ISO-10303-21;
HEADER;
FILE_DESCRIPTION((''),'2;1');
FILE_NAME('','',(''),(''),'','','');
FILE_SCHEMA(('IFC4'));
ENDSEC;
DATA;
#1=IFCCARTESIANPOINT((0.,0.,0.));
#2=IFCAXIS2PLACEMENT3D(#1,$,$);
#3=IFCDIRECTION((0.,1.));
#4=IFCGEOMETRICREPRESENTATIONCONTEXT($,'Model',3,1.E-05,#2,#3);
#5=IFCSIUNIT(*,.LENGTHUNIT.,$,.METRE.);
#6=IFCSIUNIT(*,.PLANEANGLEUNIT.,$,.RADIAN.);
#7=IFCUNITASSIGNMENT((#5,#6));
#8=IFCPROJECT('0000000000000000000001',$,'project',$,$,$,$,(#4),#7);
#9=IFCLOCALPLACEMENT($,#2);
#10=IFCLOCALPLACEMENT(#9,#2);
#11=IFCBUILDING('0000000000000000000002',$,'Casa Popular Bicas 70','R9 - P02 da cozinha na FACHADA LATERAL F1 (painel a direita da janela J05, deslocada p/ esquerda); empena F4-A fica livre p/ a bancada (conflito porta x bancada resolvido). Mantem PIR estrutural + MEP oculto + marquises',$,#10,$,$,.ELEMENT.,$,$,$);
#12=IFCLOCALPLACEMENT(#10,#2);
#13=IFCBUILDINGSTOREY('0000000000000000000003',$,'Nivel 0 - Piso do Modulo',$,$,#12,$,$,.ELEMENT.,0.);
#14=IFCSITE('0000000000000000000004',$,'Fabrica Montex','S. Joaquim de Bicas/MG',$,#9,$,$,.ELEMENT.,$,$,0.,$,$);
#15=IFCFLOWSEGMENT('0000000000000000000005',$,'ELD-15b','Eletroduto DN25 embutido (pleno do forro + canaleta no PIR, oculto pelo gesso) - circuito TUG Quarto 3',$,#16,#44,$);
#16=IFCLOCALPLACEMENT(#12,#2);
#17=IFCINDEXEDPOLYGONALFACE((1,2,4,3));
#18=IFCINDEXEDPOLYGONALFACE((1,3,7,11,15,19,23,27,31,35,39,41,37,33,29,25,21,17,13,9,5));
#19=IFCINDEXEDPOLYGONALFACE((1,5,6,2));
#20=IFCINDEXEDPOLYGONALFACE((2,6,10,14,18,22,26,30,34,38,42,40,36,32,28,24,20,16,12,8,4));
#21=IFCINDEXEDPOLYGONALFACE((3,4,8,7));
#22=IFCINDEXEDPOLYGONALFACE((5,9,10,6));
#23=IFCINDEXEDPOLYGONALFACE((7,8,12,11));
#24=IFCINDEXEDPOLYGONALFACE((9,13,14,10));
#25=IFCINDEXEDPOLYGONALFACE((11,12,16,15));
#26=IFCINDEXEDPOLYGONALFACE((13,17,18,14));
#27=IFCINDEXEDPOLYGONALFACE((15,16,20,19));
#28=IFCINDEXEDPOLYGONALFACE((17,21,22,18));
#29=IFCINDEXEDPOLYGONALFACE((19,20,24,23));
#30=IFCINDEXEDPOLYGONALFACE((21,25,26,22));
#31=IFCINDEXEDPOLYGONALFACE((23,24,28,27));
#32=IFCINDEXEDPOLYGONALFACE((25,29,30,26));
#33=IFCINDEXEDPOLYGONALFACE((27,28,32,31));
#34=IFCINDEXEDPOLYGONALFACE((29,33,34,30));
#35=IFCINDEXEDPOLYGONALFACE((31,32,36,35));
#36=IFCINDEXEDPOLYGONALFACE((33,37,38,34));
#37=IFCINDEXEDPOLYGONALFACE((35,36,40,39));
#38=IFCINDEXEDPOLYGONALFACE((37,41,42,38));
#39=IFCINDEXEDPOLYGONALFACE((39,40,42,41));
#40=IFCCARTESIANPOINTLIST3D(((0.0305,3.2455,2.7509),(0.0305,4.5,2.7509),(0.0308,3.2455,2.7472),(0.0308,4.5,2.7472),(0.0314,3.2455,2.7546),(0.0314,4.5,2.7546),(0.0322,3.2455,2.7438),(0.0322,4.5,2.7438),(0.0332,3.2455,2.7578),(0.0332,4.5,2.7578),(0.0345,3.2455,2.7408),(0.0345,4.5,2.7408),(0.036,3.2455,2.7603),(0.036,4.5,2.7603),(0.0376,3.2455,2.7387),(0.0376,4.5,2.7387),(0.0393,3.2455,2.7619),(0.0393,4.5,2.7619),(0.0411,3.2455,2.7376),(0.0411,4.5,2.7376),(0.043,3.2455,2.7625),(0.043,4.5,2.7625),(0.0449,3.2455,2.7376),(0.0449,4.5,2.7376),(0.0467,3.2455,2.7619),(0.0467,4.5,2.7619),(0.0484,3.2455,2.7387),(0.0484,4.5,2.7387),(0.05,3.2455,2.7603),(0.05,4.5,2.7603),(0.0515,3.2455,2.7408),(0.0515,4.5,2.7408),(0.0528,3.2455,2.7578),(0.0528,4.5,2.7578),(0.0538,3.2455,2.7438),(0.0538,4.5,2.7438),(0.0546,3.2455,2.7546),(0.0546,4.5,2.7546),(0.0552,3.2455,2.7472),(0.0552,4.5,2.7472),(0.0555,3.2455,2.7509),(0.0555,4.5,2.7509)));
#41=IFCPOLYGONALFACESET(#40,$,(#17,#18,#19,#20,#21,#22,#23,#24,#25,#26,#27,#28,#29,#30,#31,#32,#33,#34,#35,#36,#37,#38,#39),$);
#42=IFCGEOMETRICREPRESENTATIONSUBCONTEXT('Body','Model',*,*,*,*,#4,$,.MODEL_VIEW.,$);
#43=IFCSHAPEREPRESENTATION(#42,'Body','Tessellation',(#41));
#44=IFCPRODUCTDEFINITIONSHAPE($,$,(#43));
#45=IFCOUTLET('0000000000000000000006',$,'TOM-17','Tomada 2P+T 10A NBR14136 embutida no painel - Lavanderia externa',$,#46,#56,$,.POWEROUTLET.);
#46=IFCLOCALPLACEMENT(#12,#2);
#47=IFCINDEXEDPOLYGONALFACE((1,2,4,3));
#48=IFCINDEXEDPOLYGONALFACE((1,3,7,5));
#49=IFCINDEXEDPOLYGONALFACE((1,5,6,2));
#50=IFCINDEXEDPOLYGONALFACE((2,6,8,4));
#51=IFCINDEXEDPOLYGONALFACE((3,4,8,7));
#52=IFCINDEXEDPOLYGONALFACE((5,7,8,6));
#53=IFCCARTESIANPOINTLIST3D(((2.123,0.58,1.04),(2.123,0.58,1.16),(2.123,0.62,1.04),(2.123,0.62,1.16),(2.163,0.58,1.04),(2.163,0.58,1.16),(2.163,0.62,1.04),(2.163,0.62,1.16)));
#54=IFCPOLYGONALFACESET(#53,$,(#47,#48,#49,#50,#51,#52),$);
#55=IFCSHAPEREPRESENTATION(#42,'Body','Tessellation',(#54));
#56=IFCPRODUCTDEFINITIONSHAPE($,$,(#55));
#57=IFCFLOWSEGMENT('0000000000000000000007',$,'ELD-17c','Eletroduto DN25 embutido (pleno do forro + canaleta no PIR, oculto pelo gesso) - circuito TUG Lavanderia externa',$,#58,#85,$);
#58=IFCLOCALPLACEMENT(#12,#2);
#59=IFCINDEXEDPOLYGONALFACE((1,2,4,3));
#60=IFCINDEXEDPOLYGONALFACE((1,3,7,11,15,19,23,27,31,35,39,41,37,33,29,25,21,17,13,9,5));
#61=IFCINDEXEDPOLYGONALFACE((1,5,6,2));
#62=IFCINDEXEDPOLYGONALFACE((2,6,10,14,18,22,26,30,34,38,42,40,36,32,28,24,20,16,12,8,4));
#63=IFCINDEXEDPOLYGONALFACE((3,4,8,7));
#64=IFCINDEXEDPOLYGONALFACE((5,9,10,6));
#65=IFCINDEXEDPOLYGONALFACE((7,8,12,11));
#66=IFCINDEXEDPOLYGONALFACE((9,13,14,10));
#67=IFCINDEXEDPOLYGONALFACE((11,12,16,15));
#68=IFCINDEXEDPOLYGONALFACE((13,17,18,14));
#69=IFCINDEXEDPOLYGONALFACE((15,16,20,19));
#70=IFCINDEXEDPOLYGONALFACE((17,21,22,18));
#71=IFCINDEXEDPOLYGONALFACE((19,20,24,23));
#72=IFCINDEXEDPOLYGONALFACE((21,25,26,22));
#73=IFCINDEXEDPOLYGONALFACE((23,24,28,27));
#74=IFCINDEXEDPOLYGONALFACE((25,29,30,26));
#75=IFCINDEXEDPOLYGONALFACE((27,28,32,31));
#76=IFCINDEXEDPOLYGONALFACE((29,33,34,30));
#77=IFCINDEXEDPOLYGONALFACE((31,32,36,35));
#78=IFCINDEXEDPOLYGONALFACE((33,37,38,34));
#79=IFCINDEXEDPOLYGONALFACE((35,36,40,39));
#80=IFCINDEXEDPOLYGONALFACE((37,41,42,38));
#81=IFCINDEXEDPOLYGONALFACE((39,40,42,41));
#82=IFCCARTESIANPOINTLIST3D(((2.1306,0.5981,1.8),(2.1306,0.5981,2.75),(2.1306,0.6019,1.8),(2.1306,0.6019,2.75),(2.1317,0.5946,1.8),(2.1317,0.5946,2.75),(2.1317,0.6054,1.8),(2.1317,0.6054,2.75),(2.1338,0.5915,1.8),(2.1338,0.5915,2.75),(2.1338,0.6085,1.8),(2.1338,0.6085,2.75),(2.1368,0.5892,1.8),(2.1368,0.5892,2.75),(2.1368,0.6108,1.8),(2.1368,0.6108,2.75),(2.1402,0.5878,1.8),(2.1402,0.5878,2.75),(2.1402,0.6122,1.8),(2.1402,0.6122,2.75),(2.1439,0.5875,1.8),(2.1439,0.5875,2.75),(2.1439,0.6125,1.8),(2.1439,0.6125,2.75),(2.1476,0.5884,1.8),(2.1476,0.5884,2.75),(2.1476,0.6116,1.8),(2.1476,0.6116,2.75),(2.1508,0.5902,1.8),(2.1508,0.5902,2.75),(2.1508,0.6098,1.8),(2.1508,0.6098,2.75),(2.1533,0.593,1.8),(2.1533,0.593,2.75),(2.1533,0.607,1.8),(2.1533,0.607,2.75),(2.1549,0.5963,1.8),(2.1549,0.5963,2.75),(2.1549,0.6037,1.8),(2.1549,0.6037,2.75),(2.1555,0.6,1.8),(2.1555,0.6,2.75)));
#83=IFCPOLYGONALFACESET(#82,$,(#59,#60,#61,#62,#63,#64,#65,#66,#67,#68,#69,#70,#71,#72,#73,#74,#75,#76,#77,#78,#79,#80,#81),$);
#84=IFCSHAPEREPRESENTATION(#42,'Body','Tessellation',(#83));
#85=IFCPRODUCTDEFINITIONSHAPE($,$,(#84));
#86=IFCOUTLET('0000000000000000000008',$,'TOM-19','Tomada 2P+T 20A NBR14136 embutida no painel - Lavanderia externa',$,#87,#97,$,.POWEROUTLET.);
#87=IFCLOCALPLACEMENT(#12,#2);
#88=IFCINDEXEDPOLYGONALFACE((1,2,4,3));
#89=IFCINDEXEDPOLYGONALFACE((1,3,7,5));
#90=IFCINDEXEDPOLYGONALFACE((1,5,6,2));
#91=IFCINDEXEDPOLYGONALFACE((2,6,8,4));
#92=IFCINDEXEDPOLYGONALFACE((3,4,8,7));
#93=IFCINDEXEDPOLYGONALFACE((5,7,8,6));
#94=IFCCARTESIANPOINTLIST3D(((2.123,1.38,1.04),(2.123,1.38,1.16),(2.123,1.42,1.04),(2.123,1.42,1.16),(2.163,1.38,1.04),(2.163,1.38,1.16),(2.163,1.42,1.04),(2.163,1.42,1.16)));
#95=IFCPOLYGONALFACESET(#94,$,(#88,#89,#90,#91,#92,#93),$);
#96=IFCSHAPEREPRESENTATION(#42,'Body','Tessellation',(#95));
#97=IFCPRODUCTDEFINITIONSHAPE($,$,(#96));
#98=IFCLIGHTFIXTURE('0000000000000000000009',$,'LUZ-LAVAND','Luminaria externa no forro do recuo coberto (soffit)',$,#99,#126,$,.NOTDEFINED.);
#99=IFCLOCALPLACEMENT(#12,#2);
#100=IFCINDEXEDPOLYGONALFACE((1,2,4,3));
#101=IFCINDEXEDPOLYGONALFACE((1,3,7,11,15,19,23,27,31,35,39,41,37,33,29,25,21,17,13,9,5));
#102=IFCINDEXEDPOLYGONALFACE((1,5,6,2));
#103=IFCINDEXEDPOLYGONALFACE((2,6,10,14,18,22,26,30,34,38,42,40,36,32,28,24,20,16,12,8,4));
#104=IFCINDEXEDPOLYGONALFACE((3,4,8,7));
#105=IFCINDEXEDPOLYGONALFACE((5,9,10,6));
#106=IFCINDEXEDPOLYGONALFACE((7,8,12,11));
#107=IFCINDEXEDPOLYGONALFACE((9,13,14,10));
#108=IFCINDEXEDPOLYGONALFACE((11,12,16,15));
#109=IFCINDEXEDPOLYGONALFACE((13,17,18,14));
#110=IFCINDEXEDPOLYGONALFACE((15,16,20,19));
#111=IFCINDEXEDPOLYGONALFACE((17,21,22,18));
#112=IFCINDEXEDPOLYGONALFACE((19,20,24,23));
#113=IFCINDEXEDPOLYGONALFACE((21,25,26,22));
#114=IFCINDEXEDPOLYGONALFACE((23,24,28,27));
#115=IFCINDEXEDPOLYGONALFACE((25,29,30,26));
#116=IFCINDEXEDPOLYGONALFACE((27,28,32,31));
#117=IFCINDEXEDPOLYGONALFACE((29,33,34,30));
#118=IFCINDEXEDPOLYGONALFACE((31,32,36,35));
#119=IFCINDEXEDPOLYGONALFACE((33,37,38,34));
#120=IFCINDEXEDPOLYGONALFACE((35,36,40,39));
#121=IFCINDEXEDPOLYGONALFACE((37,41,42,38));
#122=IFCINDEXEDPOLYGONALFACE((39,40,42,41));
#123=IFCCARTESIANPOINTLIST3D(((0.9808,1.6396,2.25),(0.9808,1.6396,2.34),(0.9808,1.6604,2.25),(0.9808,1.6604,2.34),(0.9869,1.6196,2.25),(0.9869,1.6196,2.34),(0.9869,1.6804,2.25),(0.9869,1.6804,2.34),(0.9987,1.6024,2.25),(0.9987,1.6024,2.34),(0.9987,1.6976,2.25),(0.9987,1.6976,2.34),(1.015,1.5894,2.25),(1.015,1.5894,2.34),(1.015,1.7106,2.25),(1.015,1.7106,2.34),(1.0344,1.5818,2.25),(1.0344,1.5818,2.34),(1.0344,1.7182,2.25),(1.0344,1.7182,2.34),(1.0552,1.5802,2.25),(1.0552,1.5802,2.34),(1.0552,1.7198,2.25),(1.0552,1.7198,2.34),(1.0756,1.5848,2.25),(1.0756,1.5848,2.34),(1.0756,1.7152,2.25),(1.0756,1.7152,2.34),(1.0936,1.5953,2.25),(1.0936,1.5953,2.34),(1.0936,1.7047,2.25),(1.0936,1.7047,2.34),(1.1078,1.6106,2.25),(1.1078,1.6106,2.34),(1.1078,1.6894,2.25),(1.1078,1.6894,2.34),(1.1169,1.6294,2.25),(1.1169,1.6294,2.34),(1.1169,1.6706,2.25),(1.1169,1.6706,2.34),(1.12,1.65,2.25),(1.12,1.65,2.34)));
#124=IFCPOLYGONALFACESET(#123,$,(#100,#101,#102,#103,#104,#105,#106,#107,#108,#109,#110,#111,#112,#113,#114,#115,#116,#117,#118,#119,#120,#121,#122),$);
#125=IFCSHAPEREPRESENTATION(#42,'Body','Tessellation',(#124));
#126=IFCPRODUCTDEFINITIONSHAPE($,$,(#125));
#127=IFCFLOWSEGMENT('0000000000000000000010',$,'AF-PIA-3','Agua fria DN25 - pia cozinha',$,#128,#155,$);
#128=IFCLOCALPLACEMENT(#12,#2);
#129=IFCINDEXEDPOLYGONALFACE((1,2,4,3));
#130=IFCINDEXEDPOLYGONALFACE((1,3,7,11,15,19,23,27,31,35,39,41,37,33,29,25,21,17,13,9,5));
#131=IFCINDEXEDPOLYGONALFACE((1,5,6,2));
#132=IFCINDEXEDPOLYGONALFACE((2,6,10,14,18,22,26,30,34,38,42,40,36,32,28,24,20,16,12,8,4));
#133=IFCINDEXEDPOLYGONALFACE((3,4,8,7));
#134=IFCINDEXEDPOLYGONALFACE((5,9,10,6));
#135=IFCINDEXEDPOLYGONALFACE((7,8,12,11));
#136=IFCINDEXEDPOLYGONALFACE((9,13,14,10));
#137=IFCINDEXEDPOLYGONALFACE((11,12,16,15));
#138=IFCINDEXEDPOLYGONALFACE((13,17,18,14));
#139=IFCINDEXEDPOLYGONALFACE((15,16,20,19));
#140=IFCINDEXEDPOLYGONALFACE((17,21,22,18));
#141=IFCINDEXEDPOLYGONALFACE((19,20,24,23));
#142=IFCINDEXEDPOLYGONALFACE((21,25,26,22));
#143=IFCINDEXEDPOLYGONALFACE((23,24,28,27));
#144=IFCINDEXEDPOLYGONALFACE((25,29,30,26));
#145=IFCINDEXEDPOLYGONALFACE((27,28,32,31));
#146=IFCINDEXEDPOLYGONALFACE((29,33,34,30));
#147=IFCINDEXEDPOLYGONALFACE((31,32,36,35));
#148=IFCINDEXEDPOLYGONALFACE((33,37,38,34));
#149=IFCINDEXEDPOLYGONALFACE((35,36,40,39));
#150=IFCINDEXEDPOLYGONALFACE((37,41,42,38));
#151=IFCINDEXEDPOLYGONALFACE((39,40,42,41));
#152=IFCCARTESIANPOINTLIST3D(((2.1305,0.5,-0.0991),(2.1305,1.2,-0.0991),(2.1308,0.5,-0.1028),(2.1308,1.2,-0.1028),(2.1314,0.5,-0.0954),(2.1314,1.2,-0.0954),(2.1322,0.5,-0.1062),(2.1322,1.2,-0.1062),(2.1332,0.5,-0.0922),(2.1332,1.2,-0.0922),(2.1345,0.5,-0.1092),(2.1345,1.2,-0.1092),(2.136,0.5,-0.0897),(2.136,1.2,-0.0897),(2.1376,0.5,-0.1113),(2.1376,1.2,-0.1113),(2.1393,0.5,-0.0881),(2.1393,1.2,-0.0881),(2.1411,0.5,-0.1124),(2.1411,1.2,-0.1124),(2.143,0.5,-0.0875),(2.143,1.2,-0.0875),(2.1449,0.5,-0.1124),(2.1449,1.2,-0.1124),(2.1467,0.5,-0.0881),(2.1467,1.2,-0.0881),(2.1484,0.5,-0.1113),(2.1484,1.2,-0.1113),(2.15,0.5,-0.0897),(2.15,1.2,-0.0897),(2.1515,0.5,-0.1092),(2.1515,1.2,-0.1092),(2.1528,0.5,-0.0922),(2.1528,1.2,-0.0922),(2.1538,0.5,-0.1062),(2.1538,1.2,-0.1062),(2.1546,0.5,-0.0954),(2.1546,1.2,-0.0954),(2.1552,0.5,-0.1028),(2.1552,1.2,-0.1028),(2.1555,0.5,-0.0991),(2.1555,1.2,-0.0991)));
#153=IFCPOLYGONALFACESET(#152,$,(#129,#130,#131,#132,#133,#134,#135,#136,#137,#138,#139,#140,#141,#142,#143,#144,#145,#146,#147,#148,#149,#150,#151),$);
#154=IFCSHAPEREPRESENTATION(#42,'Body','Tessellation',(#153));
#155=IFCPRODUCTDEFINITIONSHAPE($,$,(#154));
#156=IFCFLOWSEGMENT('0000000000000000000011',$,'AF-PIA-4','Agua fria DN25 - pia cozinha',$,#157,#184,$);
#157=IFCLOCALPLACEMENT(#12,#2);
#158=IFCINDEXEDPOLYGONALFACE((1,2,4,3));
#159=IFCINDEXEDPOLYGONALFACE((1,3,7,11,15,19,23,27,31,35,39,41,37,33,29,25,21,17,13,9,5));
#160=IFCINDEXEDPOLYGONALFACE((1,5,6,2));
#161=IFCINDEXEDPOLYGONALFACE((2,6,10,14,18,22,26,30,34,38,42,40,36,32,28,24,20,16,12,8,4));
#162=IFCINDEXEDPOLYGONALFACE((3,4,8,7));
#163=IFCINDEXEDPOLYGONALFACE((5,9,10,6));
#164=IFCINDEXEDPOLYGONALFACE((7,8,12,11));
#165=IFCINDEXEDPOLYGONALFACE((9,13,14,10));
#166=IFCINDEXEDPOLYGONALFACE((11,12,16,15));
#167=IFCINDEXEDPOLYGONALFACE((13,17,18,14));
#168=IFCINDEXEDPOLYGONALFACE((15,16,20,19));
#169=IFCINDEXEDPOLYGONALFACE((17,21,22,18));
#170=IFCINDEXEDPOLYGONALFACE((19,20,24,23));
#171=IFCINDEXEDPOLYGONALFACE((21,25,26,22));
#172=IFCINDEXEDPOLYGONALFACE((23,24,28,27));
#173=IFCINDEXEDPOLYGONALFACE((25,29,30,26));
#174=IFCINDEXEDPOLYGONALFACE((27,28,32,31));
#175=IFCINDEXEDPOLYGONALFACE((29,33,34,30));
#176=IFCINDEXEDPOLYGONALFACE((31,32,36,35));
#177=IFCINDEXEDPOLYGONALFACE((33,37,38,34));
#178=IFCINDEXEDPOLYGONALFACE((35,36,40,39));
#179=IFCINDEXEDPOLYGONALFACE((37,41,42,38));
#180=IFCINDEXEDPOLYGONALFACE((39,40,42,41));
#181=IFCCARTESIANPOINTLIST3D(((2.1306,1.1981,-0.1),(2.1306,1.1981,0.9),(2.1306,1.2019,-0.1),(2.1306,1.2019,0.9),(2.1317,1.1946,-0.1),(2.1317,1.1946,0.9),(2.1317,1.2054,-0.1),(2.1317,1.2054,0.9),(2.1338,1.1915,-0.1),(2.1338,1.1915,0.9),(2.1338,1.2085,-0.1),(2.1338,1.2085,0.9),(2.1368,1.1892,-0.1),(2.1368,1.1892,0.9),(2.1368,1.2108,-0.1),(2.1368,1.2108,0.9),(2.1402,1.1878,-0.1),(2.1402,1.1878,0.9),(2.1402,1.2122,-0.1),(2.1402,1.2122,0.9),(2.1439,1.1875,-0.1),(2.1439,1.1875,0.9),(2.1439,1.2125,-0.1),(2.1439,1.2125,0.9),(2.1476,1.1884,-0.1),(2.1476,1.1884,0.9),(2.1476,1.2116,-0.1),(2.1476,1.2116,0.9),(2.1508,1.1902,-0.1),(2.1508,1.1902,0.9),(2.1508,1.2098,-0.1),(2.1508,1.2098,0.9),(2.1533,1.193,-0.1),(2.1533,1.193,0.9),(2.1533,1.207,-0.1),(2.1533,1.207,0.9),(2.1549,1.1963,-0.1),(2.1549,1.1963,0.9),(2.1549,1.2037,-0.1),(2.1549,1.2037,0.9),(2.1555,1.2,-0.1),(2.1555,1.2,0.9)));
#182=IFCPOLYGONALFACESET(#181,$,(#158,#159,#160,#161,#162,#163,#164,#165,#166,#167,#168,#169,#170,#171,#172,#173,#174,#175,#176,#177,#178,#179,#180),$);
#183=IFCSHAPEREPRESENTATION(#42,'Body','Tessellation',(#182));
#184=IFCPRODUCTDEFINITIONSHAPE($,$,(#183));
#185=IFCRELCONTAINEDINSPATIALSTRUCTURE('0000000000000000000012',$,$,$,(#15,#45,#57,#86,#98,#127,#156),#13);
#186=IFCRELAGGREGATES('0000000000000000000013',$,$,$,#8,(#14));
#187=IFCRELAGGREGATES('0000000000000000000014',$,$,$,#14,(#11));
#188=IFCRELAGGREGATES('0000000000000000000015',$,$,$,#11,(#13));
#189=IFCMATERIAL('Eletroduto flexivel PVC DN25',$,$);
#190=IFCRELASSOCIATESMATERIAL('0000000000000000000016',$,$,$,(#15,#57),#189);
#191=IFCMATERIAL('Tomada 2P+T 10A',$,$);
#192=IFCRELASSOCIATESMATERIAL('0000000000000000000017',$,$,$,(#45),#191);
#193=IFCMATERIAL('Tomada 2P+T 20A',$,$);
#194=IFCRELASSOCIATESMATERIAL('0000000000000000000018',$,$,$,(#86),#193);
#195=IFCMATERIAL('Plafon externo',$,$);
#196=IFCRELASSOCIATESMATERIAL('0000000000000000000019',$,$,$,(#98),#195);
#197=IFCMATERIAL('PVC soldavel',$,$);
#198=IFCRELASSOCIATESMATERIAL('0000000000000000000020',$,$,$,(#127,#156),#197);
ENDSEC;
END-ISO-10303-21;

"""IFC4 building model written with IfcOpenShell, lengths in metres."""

from ifc_helpers import new_model, si_unit, direction, frame, frame_2d, origin, origin_2d, place, context, subcontext, project, spatial, rectangle, circle, extrude, material, element, save


model = new_model("IFC4")

# Units and contexts
model_context = context("Model", 3, precision=1e-05, world=origin(), true_north=direction((0.0, 1.0)))
body_context = subcontext(model_context, "Body", "Model", "MODEL_VIEW")
ifc_project = project(units=[si_unit("LENGTHUNIT", "METRE"), si_unit("PLANEANGLEUNIT", "RADIAN")], contexts=[model_context])

# Site, building, storey
site_placement = place(None, origin())
site = spatial("IfcSite", under=ifc_project, at=site_placement, Name="Fabrica Montex", Description="S. Joaquim de Bicas/MG", CompositionType="ELEMENT", RefElevation=0.0)
building_placement = place(site_placement, origin())
building = spatial("IfcBuilding", under=site, at=building_placement, Name="Casa Popular Bicas 70", Description="R9 - P02 da cozinha na FACHADA LATERAL F1 (painel a direita da janela J05, deslocada p/ esquerda); empena F4-A fica livre p/ a bancada (conflito porta x bancada resolvido). Mantem PIR estrutural + MEP oculto + marquises", CompositionType="ELEMENT")
storey_placement = place(building_placement, origin())
storey = spatial("IfcBuildingStorey", under=building, at=storey_placement, Name="Nivel 0 - Piso do Modulo", CompositionType="ELEMENT", Elevation=0.0)

# Shared definitions
ifc_material_1 = material(Name="Tomada 2P+T 10A")

# Shared definitions
ifc_material_2 = material(Name="Eletroduto flexivel PVC DN25")

# Flow segment
flow_segment_1_placement = place(storey_placement, frame((0.043, 3.2455, 2.75), z_axis=(0.0, 1.0, 0.0), x_axis=(0.0, 0.0, 1.0)))
element("IfcFlowSegment", 1, at=flow_segment_1_placement, inside=storey, material=ifc_material_2, Name="ELD-15b", Description="Eletroduto DN25 embutido (pleno do forro + canaleta no PIR, oculto pelo gesso) - circuito TUG Quarto 3", context=body_context, shape_type="SweptSolid", body=[
    extrude(circle(Radius=0.0125, at=origin_2d()), origin(), (0.0, 0.0, 1.0), 1.2545),
])

# Outlet
outlet_1_placement = place(storey_placement, frame((2.123, 0.58, 1.04)))
element("IfcOutlet", 2, at=outlet_1_placement, inside=storey, material=ifc_material_1, Name="TOM-17", Description="Tomada 2P+T 10A NBR14136 embutida no painel - Lavanderia externa", PredefinedType="POWEROUTLET", context=body_context, shape_type="SweptSolid", body=[
    extrude(rectangle(XDim=0.04, YDim=0.04, at=frame_2d((0.02, 0.02))), origin(), (0.0, 0.0, 1.0), 0.12),
])

# Flow segment
flow_segment_2_placement = place(storey_placement, frame((2.143, 0.6, 2.75), z_axis=(0.0, 0.0, -1.0), x_axis=(1.0, 0.0, 0.0)))
element("IfcFlowSegment", 3, at=flow_segment_2_placement, inside=storey, material=ifc_material_2, Name="ELD-17c", Description="Eletroduto DN25 embutido (pleno do forro + canaleta no PIR, oculto pelo gesso) - circuito TUG Lavanderia externa", context=body_context, shape_type="SweptSolid", body=[
    extrude(circle(Radius=0.0125, at=origin_2d()), origin(), (0.0, 0.0, 1.0), 0.95),
])

# Outlet
ifc_material_3 = material(Name="Tomada 2P+T 20A")
outlet_2_placement = place(storey_placement, frame((2.123, 1.38, 1.04)))
element("IfcOutlet", 4, at=outlet_2_placement, inside=storey, material=ifc_material_3, Name="TOM-19", Description="Tomada 2P+T 20A NBR14136 embutida no painel - Lavanderia externa", PredefinedType="POWEROUTLET", context=body_context, shape_type="SweptSolid", body=[
    extrude(rectangle(XDim=0.04, YDim=0.04, at=frame_2d((0.02, 0.02))), origin(), (0.0, 0.0, 1.0), 0.12),
])

# Light fixture
ifc_material_4 = material(Name="Plafon externo")
light_fixture_placement = place(storey_placement, frame((1.05, 1.65, 2.25)))
element("IfcLightFixture", 5, at=light_fixture_placement, inside=storey, material=ifc_material_4, Name="LUZ-LAVAND", Description="Luminaria externa no forro do recuo coberto (soffit)", PredefinedType="NOTDEFINED", context=body_context, shape_type="SweptSolid", body=[
    extrude(circle(Radius=0.07, at=origin_2d()), origin(), (0.0, 0.0, 1.0), 0.09),
])

# Flow segments
ifc_material_5 = material(Name="PVC soldavel")
flow_segment_3_placement = place(storey_placement, frame((2.143, 0.5, -0.1), z_axis=(0.0, 1.0, 0.0), x_axis=(0.0, 0.0, 1.0)))
element("IfcFlowSegment", 6, at=flow_segment_3_placement, inside=storey, material=ifc_material_5, Name="AF-PIA-3", Description="Agua fria DN25 - pia cozinha", context=body_context, shape_type="SweptSolid", body=[
    extrude(circle(Radius=0.0125, at=origin_2d()), origin(), (0.0, 0.0, 1.0), 0.7),
])
flow_segment_4_placement = place(storey_placement, frame((2.143, 1.2, -0.1), z_axis=(0.0, 0.0, 1.0), x_axis=(1.0, 0.0, 0.0)))
element("IfcFlowSegment", 7, at=flow_segment_4_placement, inside=storey, material=ifc_material_5, Name="AF-PIA-4", Description="Agua fria DN25 - pia cozinha", context=body_context, shape_type="SweptSolid", body=[
    extrude(circle(Radius=0.0125, at=origin_2d()), origin(), (0.0, 0.0, 1.0), 1.0),
])

save(model, "model.ifc")
